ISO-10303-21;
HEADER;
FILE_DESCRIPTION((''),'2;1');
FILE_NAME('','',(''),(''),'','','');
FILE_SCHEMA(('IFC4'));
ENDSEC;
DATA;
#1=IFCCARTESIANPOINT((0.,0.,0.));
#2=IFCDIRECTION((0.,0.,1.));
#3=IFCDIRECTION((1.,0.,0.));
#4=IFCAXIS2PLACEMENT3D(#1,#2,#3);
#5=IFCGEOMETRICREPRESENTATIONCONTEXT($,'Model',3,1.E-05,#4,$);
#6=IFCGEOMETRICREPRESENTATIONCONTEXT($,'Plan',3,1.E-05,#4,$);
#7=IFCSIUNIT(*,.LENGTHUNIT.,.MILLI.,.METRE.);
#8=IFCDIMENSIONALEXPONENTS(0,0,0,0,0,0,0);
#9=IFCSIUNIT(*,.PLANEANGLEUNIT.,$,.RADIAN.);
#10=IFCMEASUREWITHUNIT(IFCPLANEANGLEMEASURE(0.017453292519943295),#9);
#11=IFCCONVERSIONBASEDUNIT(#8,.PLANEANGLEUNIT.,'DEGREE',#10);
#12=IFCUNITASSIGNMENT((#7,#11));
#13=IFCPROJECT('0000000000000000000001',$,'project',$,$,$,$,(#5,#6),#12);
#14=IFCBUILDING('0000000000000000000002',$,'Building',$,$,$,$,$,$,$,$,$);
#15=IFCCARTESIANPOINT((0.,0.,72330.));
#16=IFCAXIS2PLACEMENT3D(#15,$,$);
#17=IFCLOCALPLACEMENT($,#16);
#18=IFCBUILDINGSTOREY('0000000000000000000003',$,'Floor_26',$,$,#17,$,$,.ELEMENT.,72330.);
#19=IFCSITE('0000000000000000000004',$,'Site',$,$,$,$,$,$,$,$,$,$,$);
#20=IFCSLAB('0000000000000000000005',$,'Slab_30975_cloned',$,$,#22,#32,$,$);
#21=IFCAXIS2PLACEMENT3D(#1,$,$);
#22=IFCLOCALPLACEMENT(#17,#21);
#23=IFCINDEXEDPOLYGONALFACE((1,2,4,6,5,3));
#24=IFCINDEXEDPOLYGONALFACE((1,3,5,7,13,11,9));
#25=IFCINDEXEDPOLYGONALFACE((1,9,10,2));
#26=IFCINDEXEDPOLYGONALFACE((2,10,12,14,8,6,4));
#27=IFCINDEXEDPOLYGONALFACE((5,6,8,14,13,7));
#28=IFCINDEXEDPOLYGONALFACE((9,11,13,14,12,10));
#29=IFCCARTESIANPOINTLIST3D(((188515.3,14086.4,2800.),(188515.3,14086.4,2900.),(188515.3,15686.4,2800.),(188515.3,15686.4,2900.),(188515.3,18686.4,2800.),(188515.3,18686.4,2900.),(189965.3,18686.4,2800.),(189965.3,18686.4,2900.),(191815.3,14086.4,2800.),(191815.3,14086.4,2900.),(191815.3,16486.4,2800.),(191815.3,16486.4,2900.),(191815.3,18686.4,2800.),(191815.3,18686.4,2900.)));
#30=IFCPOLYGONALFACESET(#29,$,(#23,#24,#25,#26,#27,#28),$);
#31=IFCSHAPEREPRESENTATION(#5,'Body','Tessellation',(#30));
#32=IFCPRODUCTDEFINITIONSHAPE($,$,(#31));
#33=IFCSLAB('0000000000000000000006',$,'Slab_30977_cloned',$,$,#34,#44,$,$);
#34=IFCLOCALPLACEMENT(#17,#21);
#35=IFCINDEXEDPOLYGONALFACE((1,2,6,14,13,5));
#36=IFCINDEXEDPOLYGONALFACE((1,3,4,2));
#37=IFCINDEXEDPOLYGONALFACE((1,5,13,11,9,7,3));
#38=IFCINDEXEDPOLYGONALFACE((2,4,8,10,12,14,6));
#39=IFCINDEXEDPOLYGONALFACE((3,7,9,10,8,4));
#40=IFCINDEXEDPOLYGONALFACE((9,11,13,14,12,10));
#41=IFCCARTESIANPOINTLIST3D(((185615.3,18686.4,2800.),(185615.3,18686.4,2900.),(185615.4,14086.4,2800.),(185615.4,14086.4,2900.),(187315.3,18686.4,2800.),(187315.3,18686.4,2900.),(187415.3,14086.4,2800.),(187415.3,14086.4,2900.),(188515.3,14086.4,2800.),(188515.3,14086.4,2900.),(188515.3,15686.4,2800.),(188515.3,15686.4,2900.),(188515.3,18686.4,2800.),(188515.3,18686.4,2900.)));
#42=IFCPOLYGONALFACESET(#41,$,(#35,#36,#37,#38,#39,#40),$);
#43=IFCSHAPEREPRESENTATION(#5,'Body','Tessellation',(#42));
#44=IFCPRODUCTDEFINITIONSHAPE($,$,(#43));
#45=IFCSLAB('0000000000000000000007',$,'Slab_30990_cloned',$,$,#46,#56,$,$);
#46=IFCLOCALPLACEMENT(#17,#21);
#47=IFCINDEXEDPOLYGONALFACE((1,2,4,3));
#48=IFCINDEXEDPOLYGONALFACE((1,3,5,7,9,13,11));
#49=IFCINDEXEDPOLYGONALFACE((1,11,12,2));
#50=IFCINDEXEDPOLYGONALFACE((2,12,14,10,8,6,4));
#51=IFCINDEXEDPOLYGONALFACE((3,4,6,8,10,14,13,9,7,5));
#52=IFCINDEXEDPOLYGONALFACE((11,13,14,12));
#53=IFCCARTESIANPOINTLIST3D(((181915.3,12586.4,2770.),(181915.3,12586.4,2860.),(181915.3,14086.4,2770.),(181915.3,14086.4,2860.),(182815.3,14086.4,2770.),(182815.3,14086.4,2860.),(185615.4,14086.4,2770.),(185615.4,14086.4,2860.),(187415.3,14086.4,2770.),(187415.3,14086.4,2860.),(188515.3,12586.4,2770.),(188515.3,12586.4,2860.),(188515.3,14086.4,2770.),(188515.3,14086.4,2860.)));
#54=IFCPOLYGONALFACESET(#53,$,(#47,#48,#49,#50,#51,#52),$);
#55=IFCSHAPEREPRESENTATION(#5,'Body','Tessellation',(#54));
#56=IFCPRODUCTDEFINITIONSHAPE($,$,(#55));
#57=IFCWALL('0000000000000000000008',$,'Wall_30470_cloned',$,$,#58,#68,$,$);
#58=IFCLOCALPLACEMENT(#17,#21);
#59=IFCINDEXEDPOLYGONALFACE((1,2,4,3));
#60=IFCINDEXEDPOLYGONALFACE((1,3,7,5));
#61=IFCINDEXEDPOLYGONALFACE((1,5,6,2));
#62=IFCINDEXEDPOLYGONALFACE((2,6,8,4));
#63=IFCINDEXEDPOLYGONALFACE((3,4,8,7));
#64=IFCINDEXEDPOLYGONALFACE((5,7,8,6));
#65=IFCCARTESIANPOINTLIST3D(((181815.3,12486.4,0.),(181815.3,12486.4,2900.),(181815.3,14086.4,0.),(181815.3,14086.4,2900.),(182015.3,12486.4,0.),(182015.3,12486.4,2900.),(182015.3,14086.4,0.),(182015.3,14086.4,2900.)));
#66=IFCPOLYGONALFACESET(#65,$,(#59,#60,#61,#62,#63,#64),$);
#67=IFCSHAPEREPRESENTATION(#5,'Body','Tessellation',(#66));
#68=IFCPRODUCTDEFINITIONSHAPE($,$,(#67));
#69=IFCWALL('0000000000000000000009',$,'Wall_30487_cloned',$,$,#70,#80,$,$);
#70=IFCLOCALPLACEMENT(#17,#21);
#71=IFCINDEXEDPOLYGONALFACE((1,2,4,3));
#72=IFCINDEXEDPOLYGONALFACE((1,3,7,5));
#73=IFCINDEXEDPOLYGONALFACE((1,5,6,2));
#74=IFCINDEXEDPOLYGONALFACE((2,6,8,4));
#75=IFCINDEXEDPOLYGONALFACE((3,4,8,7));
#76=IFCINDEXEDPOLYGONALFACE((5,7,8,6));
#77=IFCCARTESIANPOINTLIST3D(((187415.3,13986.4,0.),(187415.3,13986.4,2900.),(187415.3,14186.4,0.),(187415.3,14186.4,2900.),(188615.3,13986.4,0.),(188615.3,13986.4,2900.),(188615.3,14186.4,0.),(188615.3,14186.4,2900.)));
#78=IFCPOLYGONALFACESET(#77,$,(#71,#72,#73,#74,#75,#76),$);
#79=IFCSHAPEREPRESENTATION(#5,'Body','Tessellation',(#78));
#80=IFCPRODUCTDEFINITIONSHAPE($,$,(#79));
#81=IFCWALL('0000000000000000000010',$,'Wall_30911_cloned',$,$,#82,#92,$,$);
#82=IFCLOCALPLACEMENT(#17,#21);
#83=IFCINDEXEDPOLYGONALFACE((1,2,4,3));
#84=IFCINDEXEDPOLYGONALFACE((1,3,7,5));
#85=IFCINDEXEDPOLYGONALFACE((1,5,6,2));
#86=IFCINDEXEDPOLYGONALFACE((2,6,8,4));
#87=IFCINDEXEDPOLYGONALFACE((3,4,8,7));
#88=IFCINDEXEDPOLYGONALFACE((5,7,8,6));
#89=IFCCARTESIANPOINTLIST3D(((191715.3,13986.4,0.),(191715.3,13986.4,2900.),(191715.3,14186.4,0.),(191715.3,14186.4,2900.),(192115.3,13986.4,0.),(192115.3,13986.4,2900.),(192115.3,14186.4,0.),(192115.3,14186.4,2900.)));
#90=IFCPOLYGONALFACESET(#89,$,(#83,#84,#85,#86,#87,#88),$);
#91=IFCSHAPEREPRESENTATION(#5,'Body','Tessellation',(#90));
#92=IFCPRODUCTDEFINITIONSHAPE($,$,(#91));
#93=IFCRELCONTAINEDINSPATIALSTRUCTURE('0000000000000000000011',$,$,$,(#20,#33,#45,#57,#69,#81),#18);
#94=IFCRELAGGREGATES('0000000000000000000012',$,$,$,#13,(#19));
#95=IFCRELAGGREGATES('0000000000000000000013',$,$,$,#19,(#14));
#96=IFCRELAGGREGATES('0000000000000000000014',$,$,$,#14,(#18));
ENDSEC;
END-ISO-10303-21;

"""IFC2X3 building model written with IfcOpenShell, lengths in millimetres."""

from ifc_helpers import new_model, entity, si_unit, converted_unit, frame, origin_with_axes, origin_2d, place, context, project, spatial, polyline, rectangle, outline, extrude, source, transform, mapped, element, save


model = new_model("IFC2X3")

# Units and contexts
model_context = context("Model", 3, precision=1e-05, world=origin_with_axes())
plan_context = context("Plan", 3, precision=1e-05, world=origin_with_axes())
ifc_project = project(units=[si_unit("LENGTHUNIT", "METRE", prefix="MILLI"), converted_unit("PLANEANGLEUNIT", "DEGREE", entity("IfcPlaneAngleMeasure", 0.017453292519943295), si_unit("PLANEANGLEUNIT", "RADIAN"), dimensions=[0, 0, 0, 0, 0, 0, 0])], contexts=[model_context, plan_context])

# Site, building, storey
site = spatial("IfcSite", under=ifc_project, Name="Site")
building = spatial("IfcBuilding", under=site, Name="Building")
storey_placement = place(None, frame((0.0, 0.0, 72330.0)))
storey = spatial("IfcBuildingStorey", under=building, at=storey_placement, Name="Floor_26", CompositionType="ELEMENT", Elevation=72330.0)

# Slabs
shared_shape_1 = source(origin_with_axes(), model_context, "Body", "SweptSolid", [
    extrude(outline(polyline([(0.0, 0.0), (3000.0, 0.0), (4600.0, 0.0), (4600.0, 3300.0), (2200.0, 3300.0), (0.0, 3300.0), (0.0, 1450.0)])), origin_with_axes(), (0.0, 0.0, 1.0), 100.0),
])
slab_1_placement = place(storey_placement, frame((188515.3, 18686.4, 2800.0), z_axis=(0.0, 0.0, 1.0), x_axis=(-0.027, -2999.994, 0.0)))
element("IfcSlab", 1, at=slab_1_placement, inside=storey, Name="Slab_30975_cloned", context=model_context, shape_type="MappedRepresentation", body=[
    mapped(shared_shape_1, transform((0.0, 0.0, 0.0), x_axis=(1.0, 0.0, 0.0), y_axis=(0.0, 1.0, 0.0), z_axis=(0.0, 0.0, 1.0), scale=1.0)),
])
shared_shape_2 = source(origin_with_axes(), model_context, "Body", "SweptSolid", [
    extrude(outline(polyline([(0.0, 0.0), (4600.0, 0.0), (4600.0, 1799.9), (4600.0, 2900.0), (3000.0, 2900.0), (0.0, 2900.0), (0.0, 1700.0)])), origin_with_axes(), (0.0, 0.0, 1.0), 100.0),
])
slab_2_placement = place(storey_placement, frame((185615.3, 18686.4, 2800.0), z_axis=(0.0, 0.0, 1.0), x_axis=(0.055, -4600.0, 0.0)))
element("IfcSlab", 2, at=slab_2_placement, inside=storey, Name="Slab_30977_cloned", context=model_context, shape_type="MappedRepresentation", body=[
    mapped(shared_shape_2, transform((0.0, 0.0, 0.0), x_axis=(1.0, 0.0, 0.0), y_axis=(0.0, 1.0, 0.0), z_axis=(0.0, 0.0, 1.0), scale=1.0)),
])
shared_shape_3 = source(origin_with_axes(), model_context, "Body", "SweptSolid", [
    extrude(outline(polyline([(0.0, 0.0), (1500.0, 0.0), (1500.0, 6600.0), (0.0, 6600.0), (0.0, 5500.0), (0.0, 3700.1), (0.0, 900.0)])), origin_with_axes(), (0.0, 0.0, 1.0), 90.0),
])
slab_3_placement = place(storey_placement, frame((181915.3, 14086.4, 2770.0), z_axis=(0.0, 0.0, 1.0), x_axis=(0.0, -1500.0, 0.0)))
element("IfcSlab", 3, at=slab_3_placement, inside=storey, Name="Slab_30990_cloned", context=model_context, shape_type="MappedRepresentation", body=[
    mapped(shared_shape_3, transform((0.0, 0.0, 0.0), x_axis=(1.0, 0.0, 0.0), y_axis=(0.0, 1.0, 0.0), z_axis=(0.0, 0.0, 1.0), scale=1.0)),
])

# Walls
shared_shape_4 = source(origin_with_axes(), model_context, "Body", "SweptSolid", [
    extrude(rectangle(XDim=1600.0, YDim=200.0, at=origin_2d()), origin_with_axes(), (0.0, 0.0, 1.0), 2900.0),
])
wall_1_placement = place(storey_placement, frame((181915.3, 13286.4, 0.0), z_axis=(0.0, 0.0, 1.0), x_axis=(0.0, 1600.000004, 0.0)))
element("IfcWall", 4, at=wall_1_placement, inside=storey, Name="Wall_30470_cloned", context=model_context, shape_type="MappedRepresentation", body=[
    mapped(shared_shape_4, transform((0.0, 0.0, 0.0), x_axis=(1.0, 0.0, 0.0), y_axis=(0.0, 1.0, 0.0), z_axis=(0.0, 0.0, 1.0), scale=1.0)),
])
shared_shape_5 = source(origin_with_axes(), model_context, "Body", "SweptSolid", [
    extrude(rectangle(XDim=1200.0, YDim=200.0, at=origin_2d()), origin_with_axes(), (0.0, 0.0, 1.0), 2900.0),
])
wall_2_placement = place(storey_placement, frame((188015.3, 14086.4, 0.0), z_axis=(0.0, 0.0, 1.0), x_axis=(1200.020798, 0.0, 0.0)))
element("IfcWall", 5, at=wall_2_placement, inside=storey, Name="Wall_30487_cloned", context=model_context, shape_type="MappedRepresentation", body=[
    mapped(shared_shape_5, transform((0.0, 0.0, 0.0), x_axis=(1.0, 0.0, 0.0), y_axis=(0.0, 1.0, 0.0), z_axis=(0.0, 0.0, 1.0), scale=1.0)),
])
shared_shape_6 = source(origin_with_axes(), model_context, "Body", "SweptSolid", [
    extrude(rectangle(XDim=400.0, YDim=200.0, at=origin_2d()), origin_with_axes(), (0.0, 0.0, 1.0), 2900.0),
])
wall_3_placement = place(storey_placement, frame((191915.3, 14086.4, 0.0), z_axis=(0.0, 0.0, 1.0), x_axis=(400.0, 0.0, 0.0)))
element("IfcWall", 6, at=wall_3_placement, inside=storey, Name="Wall_30911_cloned", context=model_context, shape_type="MappedRepresentation", body=[
    mapped(shared_shape_6, transform((0.0, 0.0, 0.0), x_axis=(1.0, 0.0, 0.0), y_axis=(0.0, 1.0, 0.0), z_axis=(0.0, 0.0, 1.0), scale=1.0)),
])

save(model, "model.ifc")
